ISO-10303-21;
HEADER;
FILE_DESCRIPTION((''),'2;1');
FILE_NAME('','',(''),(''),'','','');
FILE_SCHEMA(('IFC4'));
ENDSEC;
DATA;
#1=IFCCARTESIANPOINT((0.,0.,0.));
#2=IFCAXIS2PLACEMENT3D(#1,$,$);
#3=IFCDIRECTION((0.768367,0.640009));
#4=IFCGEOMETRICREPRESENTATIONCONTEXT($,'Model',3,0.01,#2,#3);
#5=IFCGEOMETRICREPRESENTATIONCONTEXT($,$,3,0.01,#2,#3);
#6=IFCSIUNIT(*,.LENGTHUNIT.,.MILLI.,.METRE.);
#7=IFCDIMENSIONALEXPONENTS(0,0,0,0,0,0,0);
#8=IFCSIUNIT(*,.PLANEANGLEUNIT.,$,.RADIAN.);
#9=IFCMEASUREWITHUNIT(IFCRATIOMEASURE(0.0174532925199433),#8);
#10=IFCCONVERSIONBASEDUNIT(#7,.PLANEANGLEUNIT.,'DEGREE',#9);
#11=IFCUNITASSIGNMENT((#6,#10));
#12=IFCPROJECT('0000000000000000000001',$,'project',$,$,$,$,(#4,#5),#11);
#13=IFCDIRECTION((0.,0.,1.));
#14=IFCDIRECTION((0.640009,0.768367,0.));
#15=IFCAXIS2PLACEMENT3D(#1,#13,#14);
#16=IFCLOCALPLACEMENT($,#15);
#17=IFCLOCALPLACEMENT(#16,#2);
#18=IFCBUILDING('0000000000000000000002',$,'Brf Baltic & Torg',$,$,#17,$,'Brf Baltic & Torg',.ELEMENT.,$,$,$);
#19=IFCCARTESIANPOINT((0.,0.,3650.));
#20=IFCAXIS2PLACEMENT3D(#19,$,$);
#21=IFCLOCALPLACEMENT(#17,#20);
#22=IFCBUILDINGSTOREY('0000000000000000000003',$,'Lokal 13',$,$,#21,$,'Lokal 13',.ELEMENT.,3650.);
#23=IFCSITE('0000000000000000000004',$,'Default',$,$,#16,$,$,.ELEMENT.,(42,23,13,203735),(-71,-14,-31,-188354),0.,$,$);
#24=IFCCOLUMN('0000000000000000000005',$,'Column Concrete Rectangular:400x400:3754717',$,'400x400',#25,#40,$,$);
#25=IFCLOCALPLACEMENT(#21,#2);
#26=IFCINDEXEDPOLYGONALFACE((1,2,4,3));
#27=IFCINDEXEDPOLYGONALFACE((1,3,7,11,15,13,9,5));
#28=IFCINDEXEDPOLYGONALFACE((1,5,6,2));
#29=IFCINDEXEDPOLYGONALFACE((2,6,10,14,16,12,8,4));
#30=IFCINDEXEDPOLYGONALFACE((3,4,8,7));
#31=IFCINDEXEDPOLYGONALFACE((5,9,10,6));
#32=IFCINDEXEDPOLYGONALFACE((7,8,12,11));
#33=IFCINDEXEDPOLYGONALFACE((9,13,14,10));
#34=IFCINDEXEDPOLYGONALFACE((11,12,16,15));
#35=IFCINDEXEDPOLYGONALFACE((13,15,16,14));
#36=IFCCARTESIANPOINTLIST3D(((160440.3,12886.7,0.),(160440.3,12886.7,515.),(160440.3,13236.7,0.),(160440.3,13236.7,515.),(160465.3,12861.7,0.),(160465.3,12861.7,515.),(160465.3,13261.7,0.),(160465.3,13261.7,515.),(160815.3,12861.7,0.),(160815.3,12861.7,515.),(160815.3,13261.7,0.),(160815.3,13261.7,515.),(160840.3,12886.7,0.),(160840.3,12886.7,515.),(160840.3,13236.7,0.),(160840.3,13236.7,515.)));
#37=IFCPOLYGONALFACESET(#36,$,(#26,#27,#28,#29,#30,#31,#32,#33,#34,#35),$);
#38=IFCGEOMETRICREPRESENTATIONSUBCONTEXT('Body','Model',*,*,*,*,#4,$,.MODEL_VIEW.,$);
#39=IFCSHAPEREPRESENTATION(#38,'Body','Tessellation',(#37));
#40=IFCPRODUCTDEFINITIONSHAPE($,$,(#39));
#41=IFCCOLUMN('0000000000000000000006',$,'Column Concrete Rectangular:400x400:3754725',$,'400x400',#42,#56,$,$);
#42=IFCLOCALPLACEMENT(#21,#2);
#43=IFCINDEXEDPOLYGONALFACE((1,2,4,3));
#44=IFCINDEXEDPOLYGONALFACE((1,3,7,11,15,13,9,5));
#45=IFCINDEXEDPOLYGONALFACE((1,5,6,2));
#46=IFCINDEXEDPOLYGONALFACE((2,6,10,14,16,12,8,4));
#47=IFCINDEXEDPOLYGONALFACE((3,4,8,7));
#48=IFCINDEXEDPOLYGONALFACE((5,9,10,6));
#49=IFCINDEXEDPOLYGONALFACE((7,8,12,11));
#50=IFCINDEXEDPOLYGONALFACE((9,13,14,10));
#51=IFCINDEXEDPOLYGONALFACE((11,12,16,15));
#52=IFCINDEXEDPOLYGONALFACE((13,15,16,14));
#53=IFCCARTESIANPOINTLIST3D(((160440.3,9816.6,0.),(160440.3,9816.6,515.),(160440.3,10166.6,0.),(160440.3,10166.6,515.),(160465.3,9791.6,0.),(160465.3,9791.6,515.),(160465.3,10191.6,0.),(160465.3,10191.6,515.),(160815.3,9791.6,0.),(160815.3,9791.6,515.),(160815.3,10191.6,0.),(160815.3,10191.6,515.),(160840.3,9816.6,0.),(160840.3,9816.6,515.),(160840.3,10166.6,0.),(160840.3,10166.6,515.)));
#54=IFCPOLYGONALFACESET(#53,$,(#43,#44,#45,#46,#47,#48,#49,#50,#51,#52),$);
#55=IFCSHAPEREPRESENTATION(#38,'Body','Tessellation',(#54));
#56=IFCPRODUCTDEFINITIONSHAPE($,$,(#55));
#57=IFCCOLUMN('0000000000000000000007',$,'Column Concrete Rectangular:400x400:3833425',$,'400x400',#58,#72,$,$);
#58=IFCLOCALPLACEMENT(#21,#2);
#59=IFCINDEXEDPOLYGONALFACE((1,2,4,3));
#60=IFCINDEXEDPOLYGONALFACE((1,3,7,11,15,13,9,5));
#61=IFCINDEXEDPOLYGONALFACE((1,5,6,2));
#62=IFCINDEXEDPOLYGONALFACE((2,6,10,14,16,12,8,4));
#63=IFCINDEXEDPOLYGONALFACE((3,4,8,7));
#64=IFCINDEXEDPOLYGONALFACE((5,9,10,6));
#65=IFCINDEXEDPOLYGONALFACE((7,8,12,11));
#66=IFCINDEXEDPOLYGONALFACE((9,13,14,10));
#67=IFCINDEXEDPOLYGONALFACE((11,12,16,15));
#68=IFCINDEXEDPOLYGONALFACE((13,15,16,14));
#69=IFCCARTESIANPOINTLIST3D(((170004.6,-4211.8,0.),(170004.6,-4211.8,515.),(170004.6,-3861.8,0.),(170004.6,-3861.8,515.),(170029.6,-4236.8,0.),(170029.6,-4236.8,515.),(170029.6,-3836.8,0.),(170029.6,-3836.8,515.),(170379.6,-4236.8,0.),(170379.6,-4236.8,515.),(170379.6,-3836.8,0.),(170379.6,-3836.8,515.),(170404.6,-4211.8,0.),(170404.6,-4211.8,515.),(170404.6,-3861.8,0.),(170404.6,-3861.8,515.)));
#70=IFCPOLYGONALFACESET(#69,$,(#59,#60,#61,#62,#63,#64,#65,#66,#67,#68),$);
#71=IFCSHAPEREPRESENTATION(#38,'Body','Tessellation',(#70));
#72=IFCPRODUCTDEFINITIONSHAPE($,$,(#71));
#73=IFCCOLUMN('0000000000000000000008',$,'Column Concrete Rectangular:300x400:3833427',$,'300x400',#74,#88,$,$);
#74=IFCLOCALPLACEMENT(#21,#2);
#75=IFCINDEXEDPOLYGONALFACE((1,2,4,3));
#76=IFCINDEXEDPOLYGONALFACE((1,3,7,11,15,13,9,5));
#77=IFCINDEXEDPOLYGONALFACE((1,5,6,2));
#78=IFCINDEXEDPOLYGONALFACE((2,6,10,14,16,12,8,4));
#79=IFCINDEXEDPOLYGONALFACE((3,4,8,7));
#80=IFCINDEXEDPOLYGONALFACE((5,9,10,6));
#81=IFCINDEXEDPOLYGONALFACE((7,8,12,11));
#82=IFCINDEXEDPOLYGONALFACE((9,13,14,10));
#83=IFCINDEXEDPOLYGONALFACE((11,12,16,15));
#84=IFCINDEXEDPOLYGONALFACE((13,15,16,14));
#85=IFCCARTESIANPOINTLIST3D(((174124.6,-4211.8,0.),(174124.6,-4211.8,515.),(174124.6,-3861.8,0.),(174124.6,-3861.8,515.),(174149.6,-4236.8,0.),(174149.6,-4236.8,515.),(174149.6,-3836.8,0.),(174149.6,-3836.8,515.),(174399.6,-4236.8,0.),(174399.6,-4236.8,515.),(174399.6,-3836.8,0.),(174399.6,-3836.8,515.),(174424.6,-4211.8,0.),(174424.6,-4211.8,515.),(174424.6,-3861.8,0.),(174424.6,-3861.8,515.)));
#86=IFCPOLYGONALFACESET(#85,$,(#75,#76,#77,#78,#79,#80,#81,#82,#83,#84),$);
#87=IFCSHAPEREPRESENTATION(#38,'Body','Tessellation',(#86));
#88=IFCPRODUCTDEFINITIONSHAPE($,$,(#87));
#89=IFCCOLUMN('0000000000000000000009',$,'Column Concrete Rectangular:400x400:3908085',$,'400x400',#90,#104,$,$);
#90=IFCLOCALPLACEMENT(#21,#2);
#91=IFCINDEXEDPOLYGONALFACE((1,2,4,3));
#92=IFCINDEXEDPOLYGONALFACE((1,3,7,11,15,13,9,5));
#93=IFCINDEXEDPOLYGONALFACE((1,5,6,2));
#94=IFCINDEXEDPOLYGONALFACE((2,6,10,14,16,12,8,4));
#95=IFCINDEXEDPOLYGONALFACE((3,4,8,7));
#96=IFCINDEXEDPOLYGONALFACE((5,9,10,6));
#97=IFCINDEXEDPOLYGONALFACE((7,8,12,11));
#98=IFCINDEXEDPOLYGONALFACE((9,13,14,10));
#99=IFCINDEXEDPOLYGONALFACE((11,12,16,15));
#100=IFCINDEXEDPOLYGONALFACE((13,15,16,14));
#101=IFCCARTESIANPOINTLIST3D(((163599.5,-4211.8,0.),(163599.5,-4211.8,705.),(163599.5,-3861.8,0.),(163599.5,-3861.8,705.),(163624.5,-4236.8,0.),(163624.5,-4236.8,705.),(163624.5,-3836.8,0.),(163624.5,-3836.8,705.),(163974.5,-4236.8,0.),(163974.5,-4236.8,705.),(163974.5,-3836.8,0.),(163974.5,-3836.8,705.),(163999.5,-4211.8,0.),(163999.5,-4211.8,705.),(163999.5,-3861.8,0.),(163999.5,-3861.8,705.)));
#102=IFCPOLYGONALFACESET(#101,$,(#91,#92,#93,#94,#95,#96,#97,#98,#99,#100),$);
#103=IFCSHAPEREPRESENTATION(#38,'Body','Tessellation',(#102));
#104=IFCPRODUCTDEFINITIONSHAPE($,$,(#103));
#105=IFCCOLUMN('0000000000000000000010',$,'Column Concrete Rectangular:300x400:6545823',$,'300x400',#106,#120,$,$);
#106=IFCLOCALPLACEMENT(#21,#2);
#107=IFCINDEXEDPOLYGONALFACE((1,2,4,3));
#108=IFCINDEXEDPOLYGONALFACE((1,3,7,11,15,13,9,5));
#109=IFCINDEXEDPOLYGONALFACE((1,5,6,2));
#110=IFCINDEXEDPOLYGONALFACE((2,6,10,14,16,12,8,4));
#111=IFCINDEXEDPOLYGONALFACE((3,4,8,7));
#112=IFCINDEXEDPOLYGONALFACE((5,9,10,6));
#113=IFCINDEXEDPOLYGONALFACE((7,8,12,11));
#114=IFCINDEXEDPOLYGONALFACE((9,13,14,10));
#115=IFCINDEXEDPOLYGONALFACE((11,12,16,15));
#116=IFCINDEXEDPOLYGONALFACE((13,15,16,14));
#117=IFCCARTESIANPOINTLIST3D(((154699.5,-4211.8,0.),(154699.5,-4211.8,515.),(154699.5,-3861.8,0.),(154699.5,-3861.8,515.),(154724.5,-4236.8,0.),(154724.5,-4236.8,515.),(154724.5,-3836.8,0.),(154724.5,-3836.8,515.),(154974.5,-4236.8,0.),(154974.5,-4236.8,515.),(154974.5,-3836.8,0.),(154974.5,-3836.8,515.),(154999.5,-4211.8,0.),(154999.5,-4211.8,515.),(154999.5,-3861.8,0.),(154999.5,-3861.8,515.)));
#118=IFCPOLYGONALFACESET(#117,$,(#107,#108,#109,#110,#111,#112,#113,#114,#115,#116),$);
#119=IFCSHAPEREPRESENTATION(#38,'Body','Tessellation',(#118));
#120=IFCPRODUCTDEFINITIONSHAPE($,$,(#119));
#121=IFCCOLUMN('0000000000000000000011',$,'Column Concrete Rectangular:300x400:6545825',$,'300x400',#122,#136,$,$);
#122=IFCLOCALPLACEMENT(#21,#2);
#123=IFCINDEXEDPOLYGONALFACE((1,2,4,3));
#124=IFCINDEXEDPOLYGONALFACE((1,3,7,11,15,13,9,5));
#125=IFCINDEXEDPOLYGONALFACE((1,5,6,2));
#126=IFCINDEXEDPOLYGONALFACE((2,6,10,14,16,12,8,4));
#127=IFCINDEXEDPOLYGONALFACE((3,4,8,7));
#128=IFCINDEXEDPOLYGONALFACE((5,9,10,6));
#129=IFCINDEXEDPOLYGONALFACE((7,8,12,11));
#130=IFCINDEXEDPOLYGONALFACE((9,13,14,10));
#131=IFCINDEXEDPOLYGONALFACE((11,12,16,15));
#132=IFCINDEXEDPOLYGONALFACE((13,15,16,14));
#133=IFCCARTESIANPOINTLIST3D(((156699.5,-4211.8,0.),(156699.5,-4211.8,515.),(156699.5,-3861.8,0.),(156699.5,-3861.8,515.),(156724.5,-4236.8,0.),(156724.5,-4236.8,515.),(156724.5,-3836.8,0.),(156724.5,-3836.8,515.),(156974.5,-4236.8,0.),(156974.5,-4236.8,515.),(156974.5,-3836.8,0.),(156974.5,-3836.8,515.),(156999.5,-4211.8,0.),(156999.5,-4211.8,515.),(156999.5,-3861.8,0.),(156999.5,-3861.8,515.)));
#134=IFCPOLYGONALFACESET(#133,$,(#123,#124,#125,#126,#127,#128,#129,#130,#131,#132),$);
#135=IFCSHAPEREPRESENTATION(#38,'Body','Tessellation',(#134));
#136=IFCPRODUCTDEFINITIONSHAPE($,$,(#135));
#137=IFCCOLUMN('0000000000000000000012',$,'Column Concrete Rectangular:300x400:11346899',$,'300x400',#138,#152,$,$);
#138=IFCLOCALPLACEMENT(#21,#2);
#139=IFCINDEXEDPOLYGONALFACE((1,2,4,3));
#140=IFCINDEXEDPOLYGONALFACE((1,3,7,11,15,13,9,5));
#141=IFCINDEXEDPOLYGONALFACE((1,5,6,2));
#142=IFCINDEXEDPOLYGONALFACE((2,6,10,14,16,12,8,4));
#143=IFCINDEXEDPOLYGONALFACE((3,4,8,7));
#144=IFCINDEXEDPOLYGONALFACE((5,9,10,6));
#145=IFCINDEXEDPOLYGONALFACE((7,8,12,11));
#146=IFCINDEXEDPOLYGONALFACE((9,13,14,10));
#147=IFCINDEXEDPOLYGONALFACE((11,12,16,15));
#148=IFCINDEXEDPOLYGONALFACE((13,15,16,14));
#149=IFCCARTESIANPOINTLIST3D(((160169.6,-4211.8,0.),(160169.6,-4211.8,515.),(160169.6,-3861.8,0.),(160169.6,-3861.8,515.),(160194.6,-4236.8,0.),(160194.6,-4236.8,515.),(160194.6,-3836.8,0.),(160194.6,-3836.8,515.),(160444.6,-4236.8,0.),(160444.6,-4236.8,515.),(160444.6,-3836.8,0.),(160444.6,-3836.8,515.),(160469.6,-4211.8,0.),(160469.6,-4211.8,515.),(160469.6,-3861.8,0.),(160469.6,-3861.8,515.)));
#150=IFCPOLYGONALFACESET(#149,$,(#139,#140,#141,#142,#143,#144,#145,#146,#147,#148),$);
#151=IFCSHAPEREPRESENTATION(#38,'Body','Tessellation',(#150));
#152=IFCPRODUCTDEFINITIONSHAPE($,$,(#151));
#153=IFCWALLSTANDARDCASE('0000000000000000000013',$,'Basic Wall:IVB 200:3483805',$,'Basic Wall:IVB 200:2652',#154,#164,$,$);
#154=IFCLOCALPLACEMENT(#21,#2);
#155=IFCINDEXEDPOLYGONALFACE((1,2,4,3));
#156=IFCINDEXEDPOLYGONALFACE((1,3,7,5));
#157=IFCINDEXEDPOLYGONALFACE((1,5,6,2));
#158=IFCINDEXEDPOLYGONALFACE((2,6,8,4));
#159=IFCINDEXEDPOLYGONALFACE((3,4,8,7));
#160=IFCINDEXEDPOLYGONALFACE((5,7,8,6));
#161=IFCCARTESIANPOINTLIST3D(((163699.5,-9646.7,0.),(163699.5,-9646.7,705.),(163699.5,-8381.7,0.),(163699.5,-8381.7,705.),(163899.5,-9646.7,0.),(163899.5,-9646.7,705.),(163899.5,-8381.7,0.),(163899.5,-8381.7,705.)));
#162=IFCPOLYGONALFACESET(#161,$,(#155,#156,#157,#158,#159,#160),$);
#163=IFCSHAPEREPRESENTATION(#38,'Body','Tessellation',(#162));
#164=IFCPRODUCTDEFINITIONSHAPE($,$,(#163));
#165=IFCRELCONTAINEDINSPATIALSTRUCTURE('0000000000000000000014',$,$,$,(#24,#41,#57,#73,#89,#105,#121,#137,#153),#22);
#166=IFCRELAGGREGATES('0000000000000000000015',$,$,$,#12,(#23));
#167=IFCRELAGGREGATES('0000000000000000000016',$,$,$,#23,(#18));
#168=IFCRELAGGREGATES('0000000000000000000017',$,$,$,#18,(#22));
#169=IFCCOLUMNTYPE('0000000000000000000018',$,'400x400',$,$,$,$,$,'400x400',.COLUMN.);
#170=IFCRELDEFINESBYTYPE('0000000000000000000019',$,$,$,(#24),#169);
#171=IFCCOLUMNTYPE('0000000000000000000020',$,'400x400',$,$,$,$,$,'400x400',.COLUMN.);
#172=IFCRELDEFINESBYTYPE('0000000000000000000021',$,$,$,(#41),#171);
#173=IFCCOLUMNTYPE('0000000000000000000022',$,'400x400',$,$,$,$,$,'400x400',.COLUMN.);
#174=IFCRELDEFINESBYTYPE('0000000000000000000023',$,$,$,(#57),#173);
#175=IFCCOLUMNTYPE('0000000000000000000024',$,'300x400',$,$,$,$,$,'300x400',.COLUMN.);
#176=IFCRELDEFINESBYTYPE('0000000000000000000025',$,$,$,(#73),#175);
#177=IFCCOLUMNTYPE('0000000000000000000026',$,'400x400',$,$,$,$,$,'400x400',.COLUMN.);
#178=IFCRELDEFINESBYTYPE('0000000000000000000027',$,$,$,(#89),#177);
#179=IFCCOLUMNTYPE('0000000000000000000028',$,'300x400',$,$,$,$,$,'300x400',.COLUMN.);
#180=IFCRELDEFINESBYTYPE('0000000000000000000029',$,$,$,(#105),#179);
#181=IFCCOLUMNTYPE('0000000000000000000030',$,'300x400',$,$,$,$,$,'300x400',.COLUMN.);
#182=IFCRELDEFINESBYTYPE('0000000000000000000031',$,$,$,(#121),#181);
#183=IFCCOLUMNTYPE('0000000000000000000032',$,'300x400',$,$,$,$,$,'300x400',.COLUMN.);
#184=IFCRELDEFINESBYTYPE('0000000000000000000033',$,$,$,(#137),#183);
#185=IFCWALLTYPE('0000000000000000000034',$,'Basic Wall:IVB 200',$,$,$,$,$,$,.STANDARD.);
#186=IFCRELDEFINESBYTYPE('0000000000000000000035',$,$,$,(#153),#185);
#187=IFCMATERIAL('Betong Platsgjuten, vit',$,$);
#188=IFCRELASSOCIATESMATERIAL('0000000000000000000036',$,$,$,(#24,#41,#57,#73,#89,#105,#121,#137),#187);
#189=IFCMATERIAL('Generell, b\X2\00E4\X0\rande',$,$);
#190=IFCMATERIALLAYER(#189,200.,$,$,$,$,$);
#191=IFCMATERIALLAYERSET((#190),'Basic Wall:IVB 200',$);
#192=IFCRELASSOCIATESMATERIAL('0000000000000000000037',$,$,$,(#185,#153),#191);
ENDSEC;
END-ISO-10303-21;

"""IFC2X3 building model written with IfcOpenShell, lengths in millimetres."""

from ifc_helpers import new_model, entity, si_unit, converted_unit, direction, frame, frame_2d, origin, place, context, subcontext, project, spatial, polyline, rectangle, outline, extrude, clip, halfspace, bounded_halfspace, source, transform, mapped, material, layer, layer_set, layer_usage, type_object, type_shapes, element, save


model = new_model("IFC2X3")

# Units and contexts
model_context = context("Model", 3, precision=0.01, world=origin(), true_north=direction((0.768367, 0.640009)))
context_of_model = context(None, 3, precision=0.01, world=origin(), true_north=direction((0.768367, 0.640009)))
body_context = subcontext(model_context, "Body", "Model", "MODEL_VIEW")
ifc_project = project(units=[si_unit("LENGTHUNIT", "METRE", prefix="MILLI"), converted_unit("PLANEANGLEUNIT", "DEGREE", entity("IfcRatioMeasure", 0.0174532925199433), si_unit("PLANEANGLEUNIT", "RADIAN"), dimensions=[0, 0, 0, 0, 0, 0, 0])], contexts=[model_context, context_of_model])

# Site, building, storey
site_placement = place(None, frame((0.0, 0.0, 0.0), z_axis=(0.0, 0.0, 1.0), x_axis=(0.640009, 0.768367, 0.0)))
site = spatial("IfcSite", under=ifc_project, at=site_placement, Name="Default", CompositionType="ELEMENT", RefLatitude=(42, 23, 13, 203735), RefLongitude=(-71, -14, -31, -188354), RefElevation=0.0)
building_placement = place(site_placement, origin())
building = spatial("IfcBuilding", under=site, at=building_placement, Name="Brf Baltic & Torg", LongName="Brf Baltic & Torg", CompositionType="ELEMENT")
storey_placement = place(building_placement, frame((0.0, 0.0, 3650.0)))
storey = spatial("IfcBuildingStorey", under=building, at=storey_placement, Name="Lokal 13", LongName="Lokal 13", CompositionType="ELEMENT", Elevation=3650.0)

# Columns
ifc_material_1 = material(Name="Betong Platsgjuten, vit")
column_type_1 = type_object("IfcColumnType", Name="400x400", ElementType="400x400", PredefinedType="COLUMN")
shared_shape_1 = source(origin(), body_context, "Body", "SweptSolid", [
    extrude(outline(polyline([(-175.0, -200.0), (175.0, -200.0), (200.0, -175.0), (200.0, 175.0), (175.0, 200.0), (-175.0, 200.0), (-200.0, 175.0), (-200.0, -175.0), (-175.0, -200.0)])), frame((0.0, 0.0, 3650.0), z_axis=(0.0, 0.0, 1.0), x_axis=(0.0, -1.0, 0.0)), (0.0, 0.0, 1.0), 515.0),
])
type_shapes(column_type_1, [shared_shape_1])
column_1_placement = place(storey_placement, frame((160640.3, 13061.7, -3650.0)))
element("IfcColumn", 1, at=column_1_placement, inside=storey, type_object=column_type_1, material=ifc_material_1, Name="Column Concrete Rectangular:400x400:3754717", ObjectType="400x400", context=body_context, shape_type="MappedRepresentation", body=[
    mapped(shared_shape_1, transform((0.0, 0.0, 0.0), scale=1.0)),
])
column_type_2 = type_object("IfcColumnType", Name="400x400", ElementType="400x400", PredefinedType="COLUMN")
shared_shape_2 = source(origin(), body_context, "Body", "SweptSolid", [
    extrude(outline(polyline([(-175.0, -200.0), (175.0, -200.0), (200.0, -175.0), (200.0, 175.0), (175.0, 200.0), (-175.0, 200.0), (-200.0, 175.0), (-200.0, -175.0), (-175.0, -200.0)])), frame((0.0, 0.0, 3650.0), z_axis=(0.0, 0.0, 1.0), x_axis=(0.0, -1.0, 0.0)), (0.0, 0.0, 1.0), 515.0),
])
type_shapes(column_type_2, [shared_shape_2])
column_2_placement = place(storey_placement, frame((160640.3, 9991.6, -3650.0)))
element("IfcColumn", 2, at=column_2_placement, inside=storey, type_object=column_type_2, material=ifc_material_1, Name="Column Concrete Rectangular:400x400:3754725", ObjectType="400x400", context=body_context, shape_type="MappedRepresentation", body=[
    mapped(shared_shape_2, transform((0.0, 0.0, 0.0), scale=1.0)),
])
column_type_3 = type_object("IfcColumnType", Name="400x400", ElementType="400x400", PredefinedType="COLUMN")
shared_shape_3 = source(origin(), body_context, "Body", "SweptSolid", [
    extrude(outline(polyline([(-175.0, -200.0), (175.0, -200.0), (200.0, -175.0), (200.0, 175.0), (175.0, 200.0), (-175.0, 200.0), (-200.0, 175.0), (-200.0, -175.0), (-175.0, -200.0)])), frame((0.0, 0.0, 3650.0), z_axis=(0.0, 0.0, 1.0), x_axis=(0.0, -1.0, 0.0)), (0.0, 0.0, 1.0), 515.0),
])
type_shapes(column_type_3, [shared_shape_3])
column_3_placement = place(storey_placement, frame((170204.6, -4036.8, -3650.0)))
element("IfcColumn", 3, at=column_3_placement, inside=storey, type_object=column_type_3, material=ifc_material_1, Name="Column Concrete Rectangular:400x400:3833425", ObjectType="400x400", context=body_context, shape_type="MappedRepresentation", body=[
    mapped(shared_shape_3, transform((0.0, 0.0, 0.0), scale=1.0)),
])
column_type_4 = type_object("IfcColumnType", Name="300x400", ElementType="300x400", PredefinedType="COLUMN")
shared_shape_4 = source(origin(), body_context, "Body", "SweptSolid", [
    extrude(outline(polyline([(-175.0, -150.0), (175.0, -150.0), (200.0, -125.0), (200.0, 125.0), (175.0, 150.0), (-175.0, 150.0), (-200.0, 125.0), (-200.0, -125.0), (-175.0, -150.0)])), frame((0.0, 0.0, 3650.0), z_axis=(0.0, 0.0, 1.0), x_axis=(0.0, -1.0, 0.0)), (0.0, 0.0, 1.0), 515.0),
])
type_shapes(column_type_4, [shared_shape_4])
column_4_placement = place(storey_placement, frame((174274.6, -4036.8, -3650.0)))
element("IfcColumn", 4, at=column_4_placement, inside=storey, type_object=column_type_4, material=ifc_material_1, Name="Column Concrete Rectangular:300x400:3833427", ObjectType="300x400", context=body_context, shape_type="MappedRepresentation", body=[
    mapped(shared_shape_4, transform((0.0, 0.0, 0.0), scale=1.0)),
])
column_type_5 = type_object("IfcColumnType", Name="400x400", ElementType="400x400", PredefinedType="COLUMN")
shared_shape_5 = source(origin(), body_context, "Body", "SweptSolid", [
    extrude(outline(polyline([(-175.0, -200.0), (175.0, -200.0), (200.0, -175.0), (200.0, 175.0), (175.0, 200.0), (-175.0, 200.0), (-200.0, 175.0), (-200.0, -175.0), (-175.0, -200.0)])), frame((0.0, 0.0, 3650.0), z_axis=(0.0, 0.0, 1.0), x_axis=(0.0, -1.0, 0.0)), (0.0, 0.0, 1.0), 705.0),
])
type_shapes(column_type_5, [shared_shape_5])
column_5_placement = place(storey_placement, frame((163799.5, -4036.8, -3650.0)))
element("IfcColumn", 5, at=column_5_placement, inside=storey, type_object=column_type_5, material=ifc_material_1, Name="Column Concrete Rectangular:400x400:3908085", ObjectType="400x400", context=body_context, shape_type="MappedRepresentation", body=[
    mapped(shared_shape_5, transform((0.0, 0.0, 0.0), scale=1.0)),
])
column_type_6 = type_object("IfcColumnType", Name="300x400", ElementType="300x400", PredefinedType="COLUMN")
shared_shape_6 = source(origin(), body_context, "Body", "SweptSolid", [
    extrude(outline(polyline([(-175.0, -150.0), (175.0, -150.0), (200.0, -125.0), (200.0, 125.0), (175.0, 150.0), (-175.0, 150.0), (-200.0, 125.0), (-200.0, -125.0), (-175.0, -150.0)])), frame((0.0, 0.0, 3650.0), z_axis=(0.0, 0.0, 1.0), x_axis=(0.0, -1.0, 0.0)), (0.0, 0.0, 1.0), 515.0),
])
type_shapes(column_type_6, [shared_shape_6])
column_6_placement = place(storey_placement, frame((154849.5, -4036.8, -3650.0)))
element("IfcColumn", 6, at=column_6_placement, inside=storey, type_object=column_type_6, material=ifc_material_1, Name="Column Concrete Rectangular:300x400:6545823", ObjectType="300x400", context=body_context, shape_type="MappedRepresentation", body=[
    mapped(shared_shape_6, transform((0.0, 0.0, 0.0), scale=1.0)),
])
column_type_7 = type_object("IfcColumnType", Name="300x400", ElementType="300x400", PredefinedType="COLUMN")
shared_shape_7 = source(origin(), body_context, "Body", "SweptSolid", [
    extrude(outline(polyline([(-175.0, -150.0), (175.0, -150.0), (200.0, -125.0), (200.0, 125.0), (175.0, 150.0), (-175.0, 150.0), (-200.0, 125.0), (-200.0, -125.0), (-175.0, -150.0)])), frame((0.0, 0.0, 3650.0), z_axis=(0.0, 0.0, 1.0), x_axis=(0.0, -1.0, 0.0)), (0.0, 0.0, 1.0), 515.0),
])
type_shapes(column_type_7, [shared_shape_7])
column_7_placement = place(storey_placement, frame((156849.5, -4036.8, -3650.0)))
element("IfcColumn", 7, at=column_7_placement, inside=storey, type_object=column_type_7, material=ifc_material_1, Name="Column Concrete Rectangular:300x400:6545825", ObjectType="300x400", context=body_context, shape_type="MappedRepresentation", body=[
    mapped(shared_shape_7, transform((0.0, 0.0, 0.0), scale=1.0)),
])
column_type_8 = type_object("IfcColumnType", Name="300x400", ElementType="300x400", PredefinedType="COLUMN")
shared_shape_8 = source(origin(), body_context, "Body", "SweptSolid", [
    extrude(outline(polyline([(-175.0, -150.0), (175.0, -150.0), (200.0, -125.0), (200.0, 125.0), (175.0, 150.0), (-175.0, 150.0), (-200.0, 125.0), (-200.0, -125.0), (-175.0, -150.0)])), frame((0.0, 0.0, 3650.0), z_axis=(0.0, 0.0, 1.0), x_axis=(0.0, -1.0, 0.0)), (0.0, 0.0, 1.0), 515.0),
])
type_shapes(column_type_8, [shared_shape_8])
column_8_placement = place(storey_placement, frame((160319.6, -4036.8, -3650.0)))
element("IfcColumn", 8, at=column_8_placement, inside=storey, type_object=column_type_8, material=ifc_material_1, Name="Column Concrete Rectangular:300x400:11346899", ObjectType="300x400", context=body_context, shape_type="MappedRepresentation", body=[
    mapped(shared_shape_8, transform((0.0, 0.0, 0.0), scale=1.0)),
])

# Wall
ifc_material_2 = material(Name="Generell, bärande")
ifc_layer = layer(ifc_material_2, 200.0)
ifc_layer_set = layer_set([ifc_layer], Name="Basic Wall:IVB 200")
ifc_layer_usage_1 = layer_usage(ifc_layer_set, "AXIS2", "POSITIVE", -100.0)
wall_type = type_object("IfcWallType", Name="Basic Wall:IVB 200", PredefinedType="STANDARD", material=ifc_layer_set)
wall_1_placement = place(storey_placement, frame((163799.5, -8381.7, 0.0), z_axis=(0.0, 0.0, 1.0), x_axis=(0.0, -1.0, 0.0)))
element("IfcWallStandardCase", 9, at=wall_1_placement, inside=storey, type_object=wall_type, material=ifc_layer_usage_1, Name="Basic Wall:IVB 200:3483805", ObjectType="Basic Wall:IVB 200:2652", context=body_context, shape_type="Clipping", body=[
    clip(clip(extrude(rectangle(XDim=1265.0, YDim=200.0, at=frame_2d((632.5, 0.0), x_axis=(-1.0, 0.0))), origin(), (0.0, 0.0, 1.0), 705.0), bounded_halfspace(frame((0.0, -100.0, 705.0), z_axis=(0.0, 0.0, -1.0), x_axis=(-1.0, 0.0, 0.0)), True, frame((0.0, -100.0, 705.0)), polyline([(0.0, 0.0), (1265.0, 0.0), (1265.0, 200.0), (0.0, 200.0), (0.0, 0.0)]))), halfspace(frame((0.0, 0.0, -2000.0)), True)),
])

save(model, "model.ifc")
